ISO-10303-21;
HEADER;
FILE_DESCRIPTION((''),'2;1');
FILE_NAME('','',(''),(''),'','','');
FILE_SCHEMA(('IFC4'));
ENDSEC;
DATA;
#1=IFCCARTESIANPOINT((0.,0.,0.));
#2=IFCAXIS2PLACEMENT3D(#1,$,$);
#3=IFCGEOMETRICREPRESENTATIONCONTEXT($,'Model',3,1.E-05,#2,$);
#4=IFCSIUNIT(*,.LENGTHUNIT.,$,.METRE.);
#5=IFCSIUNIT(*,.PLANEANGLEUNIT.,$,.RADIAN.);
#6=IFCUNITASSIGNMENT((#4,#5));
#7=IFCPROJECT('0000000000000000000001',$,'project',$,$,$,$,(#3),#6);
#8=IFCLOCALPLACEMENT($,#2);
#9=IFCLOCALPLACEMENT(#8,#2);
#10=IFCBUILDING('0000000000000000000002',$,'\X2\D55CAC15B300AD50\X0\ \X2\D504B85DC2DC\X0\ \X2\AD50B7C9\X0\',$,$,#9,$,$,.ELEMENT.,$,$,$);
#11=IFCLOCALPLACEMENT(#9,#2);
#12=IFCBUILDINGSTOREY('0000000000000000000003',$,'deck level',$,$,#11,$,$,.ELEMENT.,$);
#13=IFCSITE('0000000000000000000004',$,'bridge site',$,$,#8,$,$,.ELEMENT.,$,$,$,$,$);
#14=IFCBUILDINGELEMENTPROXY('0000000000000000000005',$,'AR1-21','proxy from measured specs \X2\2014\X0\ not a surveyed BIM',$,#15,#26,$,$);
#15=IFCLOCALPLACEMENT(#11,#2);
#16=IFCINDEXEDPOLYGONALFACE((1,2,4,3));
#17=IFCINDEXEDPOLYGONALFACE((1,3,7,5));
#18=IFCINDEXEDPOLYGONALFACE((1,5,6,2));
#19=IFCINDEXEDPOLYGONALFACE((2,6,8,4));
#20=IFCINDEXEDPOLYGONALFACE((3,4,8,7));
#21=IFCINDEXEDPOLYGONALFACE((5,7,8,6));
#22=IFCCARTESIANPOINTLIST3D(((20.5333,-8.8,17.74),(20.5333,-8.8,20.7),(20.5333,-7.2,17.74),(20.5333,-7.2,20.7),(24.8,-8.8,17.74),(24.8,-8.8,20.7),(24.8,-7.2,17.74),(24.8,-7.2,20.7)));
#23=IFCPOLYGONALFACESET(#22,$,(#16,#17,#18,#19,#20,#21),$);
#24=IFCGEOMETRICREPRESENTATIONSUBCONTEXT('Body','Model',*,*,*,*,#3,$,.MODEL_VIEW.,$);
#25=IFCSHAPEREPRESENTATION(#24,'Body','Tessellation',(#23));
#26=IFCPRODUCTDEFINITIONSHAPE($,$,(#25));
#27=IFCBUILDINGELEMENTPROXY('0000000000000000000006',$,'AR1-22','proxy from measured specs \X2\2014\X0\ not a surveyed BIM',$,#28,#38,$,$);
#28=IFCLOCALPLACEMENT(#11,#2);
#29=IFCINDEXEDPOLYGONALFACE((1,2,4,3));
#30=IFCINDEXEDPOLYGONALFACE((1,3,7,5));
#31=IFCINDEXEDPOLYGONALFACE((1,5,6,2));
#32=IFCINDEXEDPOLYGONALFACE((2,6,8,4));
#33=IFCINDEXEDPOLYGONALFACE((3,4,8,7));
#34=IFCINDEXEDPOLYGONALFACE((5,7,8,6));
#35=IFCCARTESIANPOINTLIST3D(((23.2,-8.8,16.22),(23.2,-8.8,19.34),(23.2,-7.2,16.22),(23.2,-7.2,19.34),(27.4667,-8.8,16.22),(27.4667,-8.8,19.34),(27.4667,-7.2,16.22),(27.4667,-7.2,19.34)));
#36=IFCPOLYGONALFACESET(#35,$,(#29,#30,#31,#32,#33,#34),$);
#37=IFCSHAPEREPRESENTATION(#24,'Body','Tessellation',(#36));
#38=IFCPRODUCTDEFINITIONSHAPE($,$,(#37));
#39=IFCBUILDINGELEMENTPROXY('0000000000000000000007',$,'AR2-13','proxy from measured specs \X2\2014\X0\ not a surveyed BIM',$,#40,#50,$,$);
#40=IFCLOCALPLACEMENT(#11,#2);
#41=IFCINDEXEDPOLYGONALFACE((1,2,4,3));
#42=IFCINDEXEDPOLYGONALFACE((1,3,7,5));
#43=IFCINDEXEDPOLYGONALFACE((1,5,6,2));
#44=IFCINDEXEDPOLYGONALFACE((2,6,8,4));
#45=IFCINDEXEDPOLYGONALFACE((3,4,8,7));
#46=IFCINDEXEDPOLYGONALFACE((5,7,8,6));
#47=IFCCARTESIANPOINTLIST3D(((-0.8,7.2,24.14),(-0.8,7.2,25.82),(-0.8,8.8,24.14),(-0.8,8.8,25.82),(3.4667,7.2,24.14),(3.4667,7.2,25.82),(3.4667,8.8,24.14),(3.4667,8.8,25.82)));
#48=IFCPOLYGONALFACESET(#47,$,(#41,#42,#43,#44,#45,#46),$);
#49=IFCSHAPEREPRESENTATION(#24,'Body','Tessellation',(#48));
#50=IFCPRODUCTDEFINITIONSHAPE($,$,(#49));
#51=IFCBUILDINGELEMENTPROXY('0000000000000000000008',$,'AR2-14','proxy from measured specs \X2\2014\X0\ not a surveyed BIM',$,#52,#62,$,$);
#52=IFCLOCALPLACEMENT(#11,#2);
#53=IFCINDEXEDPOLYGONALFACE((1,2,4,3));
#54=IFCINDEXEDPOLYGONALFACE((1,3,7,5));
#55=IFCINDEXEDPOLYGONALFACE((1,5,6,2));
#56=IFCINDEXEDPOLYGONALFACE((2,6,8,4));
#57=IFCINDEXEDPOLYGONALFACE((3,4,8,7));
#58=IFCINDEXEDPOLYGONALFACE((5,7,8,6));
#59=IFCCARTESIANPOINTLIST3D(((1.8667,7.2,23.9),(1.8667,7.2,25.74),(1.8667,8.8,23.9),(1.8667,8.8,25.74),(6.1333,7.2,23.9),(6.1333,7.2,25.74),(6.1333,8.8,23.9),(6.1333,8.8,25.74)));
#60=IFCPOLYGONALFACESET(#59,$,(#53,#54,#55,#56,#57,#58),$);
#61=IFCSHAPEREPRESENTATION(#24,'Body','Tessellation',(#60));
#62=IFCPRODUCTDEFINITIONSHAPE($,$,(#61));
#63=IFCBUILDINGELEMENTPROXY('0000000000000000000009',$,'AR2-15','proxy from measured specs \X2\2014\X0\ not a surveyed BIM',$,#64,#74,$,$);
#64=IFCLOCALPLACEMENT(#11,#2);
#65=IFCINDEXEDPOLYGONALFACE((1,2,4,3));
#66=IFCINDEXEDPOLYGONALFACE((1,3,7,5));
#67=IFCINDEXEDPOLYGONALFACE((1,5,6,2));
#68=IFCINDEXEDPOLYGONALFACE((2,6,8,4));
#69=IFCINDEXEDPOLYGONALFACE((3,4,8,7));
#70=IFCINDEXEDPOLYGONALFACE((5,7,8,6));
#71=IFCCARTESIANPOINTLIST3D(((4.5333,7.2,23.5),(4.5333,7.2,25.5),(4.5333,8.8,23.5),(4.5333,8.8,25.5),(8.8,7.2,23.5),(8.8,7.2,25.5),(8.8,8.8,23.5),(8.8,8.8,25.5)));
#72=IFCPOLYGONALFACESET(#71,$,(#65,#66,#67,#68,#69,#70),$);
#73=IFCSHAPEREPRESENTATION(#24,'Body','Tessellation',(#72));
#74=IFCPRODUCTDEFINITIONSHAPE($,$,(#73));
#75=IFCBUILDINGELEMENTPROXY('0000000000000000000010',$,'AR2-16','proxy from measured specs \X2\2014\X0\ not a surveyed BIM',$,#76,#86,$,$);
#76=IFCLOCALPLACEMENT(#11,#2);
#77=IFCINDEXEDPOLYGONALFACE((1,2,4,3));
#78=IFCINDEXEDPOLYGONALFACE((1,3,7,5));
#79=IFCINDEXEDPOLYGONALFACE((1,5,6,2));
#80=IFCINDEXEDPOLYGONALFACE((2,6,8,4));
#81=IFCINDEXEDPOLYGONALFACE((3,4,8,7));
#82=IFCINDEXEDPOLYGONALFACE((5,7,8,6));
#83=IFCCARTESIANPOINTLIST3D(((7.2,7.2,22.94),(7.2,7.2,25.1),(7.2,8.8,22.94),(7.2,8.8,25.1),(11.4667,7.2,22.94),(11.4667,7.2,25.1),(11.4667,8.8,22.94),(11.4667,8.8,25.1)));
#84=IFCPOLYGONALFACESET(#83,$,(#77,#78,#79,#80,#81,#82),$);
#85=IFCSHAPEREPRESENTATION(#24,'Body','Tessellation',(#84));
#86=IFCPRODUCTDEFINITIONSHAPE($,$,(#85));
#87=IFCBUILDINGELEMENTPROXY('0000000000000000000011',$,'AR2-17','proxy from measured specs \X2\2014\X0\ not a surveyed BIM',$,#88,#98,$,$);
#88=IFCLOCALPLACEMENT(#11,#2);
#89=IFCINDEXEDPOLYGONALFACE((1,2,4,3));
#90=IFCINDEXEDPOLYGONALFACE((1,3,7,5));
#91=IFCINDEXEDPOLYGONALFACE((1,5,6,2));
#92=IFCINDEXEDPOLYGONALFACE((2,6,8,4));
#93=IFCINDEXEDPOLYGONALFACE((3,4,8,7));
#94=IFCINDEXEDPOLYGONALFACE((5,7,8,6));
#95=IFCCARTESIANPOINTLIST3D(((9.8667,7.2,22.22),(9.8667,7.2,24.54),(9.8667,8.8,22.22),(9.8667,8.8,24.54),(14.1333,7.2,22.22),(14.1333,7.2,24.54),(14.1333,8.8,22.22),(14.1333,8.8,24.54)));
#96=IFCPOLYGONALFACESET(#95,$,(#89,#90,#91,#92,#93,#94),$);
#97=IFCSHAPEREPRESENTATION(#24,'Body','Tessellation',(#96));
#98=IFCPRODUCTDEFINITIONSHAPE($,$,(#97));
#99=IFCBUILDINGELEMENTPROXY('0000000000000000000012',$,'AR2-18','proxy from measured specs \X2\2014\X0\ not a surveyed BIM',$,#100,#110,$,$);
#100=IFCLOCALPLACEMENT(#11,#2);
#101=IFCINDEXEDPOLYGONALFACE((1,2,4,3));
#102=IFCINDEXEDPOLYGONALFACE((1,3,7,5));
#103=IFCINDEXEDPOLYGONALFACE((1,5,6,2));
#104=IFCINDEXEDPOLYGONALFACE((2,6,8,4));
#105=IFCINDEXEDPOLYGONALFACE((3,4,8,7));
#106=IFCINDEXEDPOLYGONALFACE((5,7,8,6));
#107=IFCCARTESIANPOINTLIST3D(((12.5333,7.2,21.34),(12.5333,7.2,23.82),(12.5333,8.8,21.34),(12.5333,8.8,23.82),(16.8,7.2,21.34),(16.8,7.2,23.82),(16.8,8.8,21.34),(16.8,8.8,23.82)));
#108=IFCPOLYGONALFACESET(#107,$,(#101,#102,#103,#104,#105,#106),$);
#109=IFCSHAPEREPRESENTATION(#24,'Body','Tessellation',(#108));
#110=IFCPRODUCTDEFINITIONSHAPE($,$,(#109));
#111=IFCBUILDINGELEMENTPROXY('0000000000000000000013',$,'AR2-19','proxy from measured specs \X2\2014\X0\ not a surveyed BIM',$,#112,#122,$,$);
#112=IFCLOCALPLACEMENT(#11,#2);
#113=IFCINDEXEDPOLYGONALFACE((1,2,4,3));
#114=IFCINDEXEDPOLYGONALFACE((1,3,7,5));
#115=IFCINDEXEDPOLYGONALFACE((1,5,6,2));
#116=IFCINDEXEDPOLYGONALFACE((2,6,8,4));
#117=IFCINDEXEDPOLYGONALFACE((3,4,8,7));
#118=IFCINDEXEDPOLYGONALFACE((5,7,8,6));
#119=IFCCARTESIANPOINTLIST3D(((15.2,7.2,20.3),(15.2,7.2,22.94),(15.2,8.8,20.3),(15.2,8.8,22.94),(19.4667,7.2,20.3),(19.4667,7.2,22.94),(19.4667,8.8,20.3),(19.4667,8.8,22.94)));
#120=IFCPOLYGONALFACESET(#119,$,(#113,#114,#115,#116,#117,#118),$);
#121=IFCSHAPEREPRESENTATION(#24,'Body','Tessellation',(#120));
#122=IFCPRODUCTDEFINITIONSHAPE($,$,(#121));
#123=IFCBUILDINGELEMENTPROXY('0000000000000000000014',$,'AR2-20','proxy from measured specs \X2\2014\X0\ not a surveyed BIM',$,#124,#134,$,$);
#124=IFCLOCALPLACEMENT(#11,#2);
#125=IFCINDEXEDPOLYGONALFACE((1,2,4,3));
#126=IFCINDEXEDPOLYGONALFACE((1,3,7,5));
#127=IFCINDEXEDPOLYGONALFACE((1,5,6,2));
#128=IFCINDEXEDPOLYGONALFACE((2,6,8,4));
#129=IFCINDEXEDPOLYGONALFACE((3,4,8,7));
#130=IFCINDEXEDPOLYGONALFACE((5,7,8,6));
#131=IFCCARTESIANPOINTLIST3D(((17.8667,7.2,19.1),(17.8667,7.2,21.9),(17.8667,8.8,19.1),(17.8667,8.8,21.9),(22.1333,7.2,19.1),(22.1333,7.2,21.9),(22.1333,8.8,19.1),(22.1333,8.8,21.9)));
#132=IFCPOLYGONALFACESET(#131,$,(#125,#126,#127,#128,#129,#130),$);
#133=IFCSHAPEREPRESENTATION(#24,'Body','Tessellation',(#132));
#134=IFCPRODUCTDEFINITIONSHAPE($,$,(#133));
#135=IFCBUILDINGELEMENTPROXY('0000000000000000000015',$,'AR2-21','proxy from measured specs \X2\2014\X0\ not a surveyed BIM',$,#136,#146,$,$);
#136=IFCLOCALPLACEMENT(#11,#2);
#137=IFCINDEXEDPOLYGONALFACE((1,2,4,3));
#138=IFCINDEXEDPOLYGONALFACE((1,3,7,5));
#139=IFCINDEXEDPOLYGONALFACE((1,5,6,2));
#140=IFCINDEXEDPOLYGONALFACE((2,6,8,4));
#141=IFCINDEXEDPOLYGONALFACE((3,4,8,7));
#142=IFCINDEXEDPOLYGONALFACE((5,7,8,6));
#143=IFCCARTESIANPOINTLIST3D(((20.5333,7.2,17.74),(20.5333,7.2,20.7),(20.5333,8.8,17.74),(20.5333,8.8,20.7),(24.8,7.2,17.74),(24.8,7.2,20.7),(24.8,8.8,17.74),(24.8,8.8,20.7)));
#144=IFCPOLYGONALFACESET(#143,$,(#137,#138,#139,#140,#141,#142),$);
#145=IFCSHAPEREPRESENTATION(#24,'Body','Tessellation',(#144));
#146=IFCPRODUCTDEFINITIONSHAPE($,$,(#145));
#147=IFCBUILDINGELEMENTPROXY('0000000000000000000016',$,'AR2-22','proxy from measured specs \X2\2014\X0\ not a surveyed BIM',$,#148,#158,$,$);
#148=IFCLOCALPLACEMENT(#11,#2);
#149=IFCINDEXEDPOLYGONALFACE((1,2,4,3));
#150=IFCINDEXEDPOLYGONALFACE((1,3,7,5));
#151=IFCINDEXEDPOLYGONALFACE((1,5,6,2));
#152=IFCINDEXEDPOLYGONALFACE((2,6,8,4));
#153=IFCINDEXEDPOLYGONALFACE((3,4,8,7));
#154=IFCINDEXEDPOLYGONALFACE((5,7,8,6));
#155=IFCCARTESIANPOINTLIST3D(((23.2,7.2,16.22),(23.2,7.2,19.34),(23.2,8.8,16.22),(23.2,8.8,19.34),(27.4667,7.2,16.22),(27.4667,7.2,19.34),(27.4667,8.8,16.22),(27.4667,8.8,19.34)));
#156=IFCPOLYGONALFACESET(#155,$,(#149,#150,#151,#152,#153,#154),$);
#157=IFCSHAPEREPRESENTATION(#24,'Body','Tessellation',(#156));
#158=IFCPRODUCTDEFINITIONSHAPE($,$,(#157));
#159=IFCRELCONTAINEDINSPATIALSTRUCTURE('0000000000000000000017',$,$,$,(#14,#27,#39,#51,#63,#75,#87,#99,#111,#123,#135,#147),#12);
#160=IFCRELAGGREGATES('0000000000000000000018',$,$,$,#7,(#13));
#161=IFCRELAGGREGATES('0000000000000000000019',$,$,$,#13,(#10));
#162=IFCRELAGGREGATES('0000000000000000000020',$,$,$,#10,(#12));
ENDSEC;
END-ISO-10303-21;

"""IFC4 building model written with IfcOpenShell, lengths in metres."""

from ifc_helpers import new_model, si_unit, frame, origin, origin_2d, place, context, subcontext, project, spatial, rectangle, extrude, element, save


model = new_model("IFC4")

# Units and contexts
model_context = context("Model", 3, precision=1e-05, world=origin())
body_context = subcontext(model_context, "Body", "Model", "MODEL_VIEW")
ifc_project = project(units=[si_unit("LENGTHUNIT", "METRE"), si_unit("PLANEANGLEUNIT", "RADIAN")], contexts=[model_context])

# Site, building, storey
site_placement = place(None, origin())
site = spatial("IfcSite", under=ifc_project, at=site_placement, Name="bridge site", CompositionType="ELEMENT")
building_placement = place(site_placement, origin())
building = spatial("IfcBuilding", under=site, at=building_placement, Name="한강대교 프록시 교량", CompositionType="ELEMENT")
storey_placement = place(building_placement, origin())
storey = spatial("IfcBuildingStorey", under=building, at=storey_placement, Name="deck level", CompositionType="ELEMENT")

# Building element proxies
proxy_1_placement = place(storey_placement, frame((22.6667, -8.0, 17.74)))
element("IfcBuildingElementProxy", 1, at=proxy_1_placement, inside=storey, Name="AR1-21", Description="proxy from measured specs — not a surveyed BIM", context=body_context, shape_type="SweptSolid", body=[
    extrude(rectangle(XDim=4.2667, YDim=1.6, at=origin_2d()), origin(), (0.0, 0.0, 1.0), 2.96),
])
proxy_2_placement = place(storey_placement, frame((25.3333, -8.0, 16.22)))
element("IfcBuildingElementProxy", 2, at=proxy_2_placement, inside=storey, Name="AR1-22", Description="proxy from measured specs — not a surveyed BIM", context=body_context, shape_type="SweptSolid", body=[
    extrude(rectangle(XDim=4.2667, YDim=1.6, at=origin_2d()), origin(), (0.0, 0.0, 1.0), 3.12),
])
proxy_3_placement = place(storey_placement, frame((1.3333, 8.0, 24.14)))
element("IfcBuildingElementProxy", 3, at=proxy_3_placement, inside=storey, Name="AR2-13", Description="proxy from measured specs — not a surveyed BIM", context=body_context, shape_type="SweptSolid", body=[
    extrude(rectangle(XDim=4.2667, YDim=1.6, at=origin_2d()), origin(), (0.0, 0.0, 1.0), 1.68),
])
proxy_4_placement = place(storey_placement, frame((4.0, 8.0, 23.9)))
element("IfcBuildingElementProxy", 4, at=proxy_4_placement, inside=storey, Name="AR2-14", Description="proxy from measured specs — not a surveyed BIM", context=body_context, shape_type="SweptSolid", body=[
    extrude(rectangle(XDim=4.2667, YDim=1.6, at=origin_2d()), origin(), (0.0, 0.0, 1.0), 1.84),
])
proxy_5_placement = place(storey_placement, frame((6.6667, 8.0, 23.5)))
element("IfcBuildingElementProxy", 5, at=proxy_5_placement, inside=storey, Name="AR2-15", Description="proxy from measured specs — not a surveyed BIM", context=body_context, shape_type="SweptSolid", body=[
    extrude(rectangle(XDim=4.2667, YDim=1.6, at=origin_2d()), origin(), (0.0, 0.0, 1.0), 2.0),
])
proxy_6_placement = place(storey_placement, frame((9.3333, 8.0, 22.94)))
element("IfcBuildingElementProxy", 6, at=proxy_6_placement, inside=storey, Name="AR2-16", Description="proxy from measured specs — not a surveyed BIM", context=body_context, shape_type="SweptSolid", body=[
    extrude(rectangle(XDim=4.2667, YDim=1.6, at=origin_2d()), origin(), (0.0, 0.0, 1.0), 2.16),
])
proxy_7_placement = place(storey_placement, frame((12.0, 8.0, 22.22)))
element("IfcBuildingElementProxy", 7, at=proxy_7_placement, inside=storey, Name="AR2-17", Description="proxy from measured specs — not a surveyed BIM", context=body_context, shape_type="SweptSolid", body=[
    extrude(rectangle(XDim=4.2667, YDim=1.6, at=origin_2d()), origin(), (0.0, 0.0, 1.0), 2.32),
])
proxy_8_placement = place(storey_placement, frame((14.6667, 8.0, 21.34)))
element("IfcBuildingElementProxy", 8, at=proxy_8_placement, inside=storey, Name="AR2-18", Description="proxy from measured specs — not a surveyed BIM", context=body_context, shape_type="SweptSolid", body=[
    extrude(rectangle(XDim=4.2667, YDim=1.6, at=origin_2d()), origin(), (0.0, 0.0, 1.0), 2.48),
])
proxy_9_placement = place(storey_placement, frame((17.3333, 8.0, 20.3)))
element("IfcBuildingElementProxy", 9, at=proxy_9_placement, inside=storey, Name="AR2-19", Description="proxy from measured specs — not a surveyed BIM", context=body_context, shape_type="SweptSolid", body=[
    extrude(rectangle(XDim=4.2667, YDim=1.6, at=origin_2d()), origin(), (0.0, 0.0, 1.0), 2.64),
])
proxy_10_placement = place(storey_placement, frame((20.0, 8.0, 19.1)))
element("IfcBuildingElementProxy", 10, at=proxy_10_placement, inside=storey, Name="AR2-20", Description="proxy from measured specs — not a surveyed BIM", context=body_context, shape_type="SweptSolid", body=[
    extrude(rectangle(XDim=4.2667, YDim=1.6, at=origin_2d()), origin(), (0.0, 0.0, 1.0), 2.8),
])
proxy_11_placement = place(storey_placement, frame((22.6667, 8.0, 17.74)))
element("IfcBuildingElementProxy", 11, at=proxy_11_placement, inside=storey, Name="AR2-21", Description="proxy from measured specs — not a surveyed BIM", context=body_context, shape_type="SweptSolid", body=[
    extrude(rectangle(XDim=4.2667, YDim=1.6, at=origin_2d()), origin(), (0.0, 0.0, 1.0), 2.96),
])
proxy_12_placement = place(storey_placement, frame((25.3333, 8.0, 16.22)))
element("IfcBuildingElementProxy", 12, at=proxy_12_placement, inside=storey, Name="AR2-22", Description="proxy from measured specs — not a surveyed BIM", context=body_context, shape_type="SweptSolid", body=[
    extrude(rectangle(XDim=4.2667, YDim=1.6, at=origin_2d()), origin(), (0.0, 0.0, 1.0), 3.12),
])

save(model, "model.ifc")
